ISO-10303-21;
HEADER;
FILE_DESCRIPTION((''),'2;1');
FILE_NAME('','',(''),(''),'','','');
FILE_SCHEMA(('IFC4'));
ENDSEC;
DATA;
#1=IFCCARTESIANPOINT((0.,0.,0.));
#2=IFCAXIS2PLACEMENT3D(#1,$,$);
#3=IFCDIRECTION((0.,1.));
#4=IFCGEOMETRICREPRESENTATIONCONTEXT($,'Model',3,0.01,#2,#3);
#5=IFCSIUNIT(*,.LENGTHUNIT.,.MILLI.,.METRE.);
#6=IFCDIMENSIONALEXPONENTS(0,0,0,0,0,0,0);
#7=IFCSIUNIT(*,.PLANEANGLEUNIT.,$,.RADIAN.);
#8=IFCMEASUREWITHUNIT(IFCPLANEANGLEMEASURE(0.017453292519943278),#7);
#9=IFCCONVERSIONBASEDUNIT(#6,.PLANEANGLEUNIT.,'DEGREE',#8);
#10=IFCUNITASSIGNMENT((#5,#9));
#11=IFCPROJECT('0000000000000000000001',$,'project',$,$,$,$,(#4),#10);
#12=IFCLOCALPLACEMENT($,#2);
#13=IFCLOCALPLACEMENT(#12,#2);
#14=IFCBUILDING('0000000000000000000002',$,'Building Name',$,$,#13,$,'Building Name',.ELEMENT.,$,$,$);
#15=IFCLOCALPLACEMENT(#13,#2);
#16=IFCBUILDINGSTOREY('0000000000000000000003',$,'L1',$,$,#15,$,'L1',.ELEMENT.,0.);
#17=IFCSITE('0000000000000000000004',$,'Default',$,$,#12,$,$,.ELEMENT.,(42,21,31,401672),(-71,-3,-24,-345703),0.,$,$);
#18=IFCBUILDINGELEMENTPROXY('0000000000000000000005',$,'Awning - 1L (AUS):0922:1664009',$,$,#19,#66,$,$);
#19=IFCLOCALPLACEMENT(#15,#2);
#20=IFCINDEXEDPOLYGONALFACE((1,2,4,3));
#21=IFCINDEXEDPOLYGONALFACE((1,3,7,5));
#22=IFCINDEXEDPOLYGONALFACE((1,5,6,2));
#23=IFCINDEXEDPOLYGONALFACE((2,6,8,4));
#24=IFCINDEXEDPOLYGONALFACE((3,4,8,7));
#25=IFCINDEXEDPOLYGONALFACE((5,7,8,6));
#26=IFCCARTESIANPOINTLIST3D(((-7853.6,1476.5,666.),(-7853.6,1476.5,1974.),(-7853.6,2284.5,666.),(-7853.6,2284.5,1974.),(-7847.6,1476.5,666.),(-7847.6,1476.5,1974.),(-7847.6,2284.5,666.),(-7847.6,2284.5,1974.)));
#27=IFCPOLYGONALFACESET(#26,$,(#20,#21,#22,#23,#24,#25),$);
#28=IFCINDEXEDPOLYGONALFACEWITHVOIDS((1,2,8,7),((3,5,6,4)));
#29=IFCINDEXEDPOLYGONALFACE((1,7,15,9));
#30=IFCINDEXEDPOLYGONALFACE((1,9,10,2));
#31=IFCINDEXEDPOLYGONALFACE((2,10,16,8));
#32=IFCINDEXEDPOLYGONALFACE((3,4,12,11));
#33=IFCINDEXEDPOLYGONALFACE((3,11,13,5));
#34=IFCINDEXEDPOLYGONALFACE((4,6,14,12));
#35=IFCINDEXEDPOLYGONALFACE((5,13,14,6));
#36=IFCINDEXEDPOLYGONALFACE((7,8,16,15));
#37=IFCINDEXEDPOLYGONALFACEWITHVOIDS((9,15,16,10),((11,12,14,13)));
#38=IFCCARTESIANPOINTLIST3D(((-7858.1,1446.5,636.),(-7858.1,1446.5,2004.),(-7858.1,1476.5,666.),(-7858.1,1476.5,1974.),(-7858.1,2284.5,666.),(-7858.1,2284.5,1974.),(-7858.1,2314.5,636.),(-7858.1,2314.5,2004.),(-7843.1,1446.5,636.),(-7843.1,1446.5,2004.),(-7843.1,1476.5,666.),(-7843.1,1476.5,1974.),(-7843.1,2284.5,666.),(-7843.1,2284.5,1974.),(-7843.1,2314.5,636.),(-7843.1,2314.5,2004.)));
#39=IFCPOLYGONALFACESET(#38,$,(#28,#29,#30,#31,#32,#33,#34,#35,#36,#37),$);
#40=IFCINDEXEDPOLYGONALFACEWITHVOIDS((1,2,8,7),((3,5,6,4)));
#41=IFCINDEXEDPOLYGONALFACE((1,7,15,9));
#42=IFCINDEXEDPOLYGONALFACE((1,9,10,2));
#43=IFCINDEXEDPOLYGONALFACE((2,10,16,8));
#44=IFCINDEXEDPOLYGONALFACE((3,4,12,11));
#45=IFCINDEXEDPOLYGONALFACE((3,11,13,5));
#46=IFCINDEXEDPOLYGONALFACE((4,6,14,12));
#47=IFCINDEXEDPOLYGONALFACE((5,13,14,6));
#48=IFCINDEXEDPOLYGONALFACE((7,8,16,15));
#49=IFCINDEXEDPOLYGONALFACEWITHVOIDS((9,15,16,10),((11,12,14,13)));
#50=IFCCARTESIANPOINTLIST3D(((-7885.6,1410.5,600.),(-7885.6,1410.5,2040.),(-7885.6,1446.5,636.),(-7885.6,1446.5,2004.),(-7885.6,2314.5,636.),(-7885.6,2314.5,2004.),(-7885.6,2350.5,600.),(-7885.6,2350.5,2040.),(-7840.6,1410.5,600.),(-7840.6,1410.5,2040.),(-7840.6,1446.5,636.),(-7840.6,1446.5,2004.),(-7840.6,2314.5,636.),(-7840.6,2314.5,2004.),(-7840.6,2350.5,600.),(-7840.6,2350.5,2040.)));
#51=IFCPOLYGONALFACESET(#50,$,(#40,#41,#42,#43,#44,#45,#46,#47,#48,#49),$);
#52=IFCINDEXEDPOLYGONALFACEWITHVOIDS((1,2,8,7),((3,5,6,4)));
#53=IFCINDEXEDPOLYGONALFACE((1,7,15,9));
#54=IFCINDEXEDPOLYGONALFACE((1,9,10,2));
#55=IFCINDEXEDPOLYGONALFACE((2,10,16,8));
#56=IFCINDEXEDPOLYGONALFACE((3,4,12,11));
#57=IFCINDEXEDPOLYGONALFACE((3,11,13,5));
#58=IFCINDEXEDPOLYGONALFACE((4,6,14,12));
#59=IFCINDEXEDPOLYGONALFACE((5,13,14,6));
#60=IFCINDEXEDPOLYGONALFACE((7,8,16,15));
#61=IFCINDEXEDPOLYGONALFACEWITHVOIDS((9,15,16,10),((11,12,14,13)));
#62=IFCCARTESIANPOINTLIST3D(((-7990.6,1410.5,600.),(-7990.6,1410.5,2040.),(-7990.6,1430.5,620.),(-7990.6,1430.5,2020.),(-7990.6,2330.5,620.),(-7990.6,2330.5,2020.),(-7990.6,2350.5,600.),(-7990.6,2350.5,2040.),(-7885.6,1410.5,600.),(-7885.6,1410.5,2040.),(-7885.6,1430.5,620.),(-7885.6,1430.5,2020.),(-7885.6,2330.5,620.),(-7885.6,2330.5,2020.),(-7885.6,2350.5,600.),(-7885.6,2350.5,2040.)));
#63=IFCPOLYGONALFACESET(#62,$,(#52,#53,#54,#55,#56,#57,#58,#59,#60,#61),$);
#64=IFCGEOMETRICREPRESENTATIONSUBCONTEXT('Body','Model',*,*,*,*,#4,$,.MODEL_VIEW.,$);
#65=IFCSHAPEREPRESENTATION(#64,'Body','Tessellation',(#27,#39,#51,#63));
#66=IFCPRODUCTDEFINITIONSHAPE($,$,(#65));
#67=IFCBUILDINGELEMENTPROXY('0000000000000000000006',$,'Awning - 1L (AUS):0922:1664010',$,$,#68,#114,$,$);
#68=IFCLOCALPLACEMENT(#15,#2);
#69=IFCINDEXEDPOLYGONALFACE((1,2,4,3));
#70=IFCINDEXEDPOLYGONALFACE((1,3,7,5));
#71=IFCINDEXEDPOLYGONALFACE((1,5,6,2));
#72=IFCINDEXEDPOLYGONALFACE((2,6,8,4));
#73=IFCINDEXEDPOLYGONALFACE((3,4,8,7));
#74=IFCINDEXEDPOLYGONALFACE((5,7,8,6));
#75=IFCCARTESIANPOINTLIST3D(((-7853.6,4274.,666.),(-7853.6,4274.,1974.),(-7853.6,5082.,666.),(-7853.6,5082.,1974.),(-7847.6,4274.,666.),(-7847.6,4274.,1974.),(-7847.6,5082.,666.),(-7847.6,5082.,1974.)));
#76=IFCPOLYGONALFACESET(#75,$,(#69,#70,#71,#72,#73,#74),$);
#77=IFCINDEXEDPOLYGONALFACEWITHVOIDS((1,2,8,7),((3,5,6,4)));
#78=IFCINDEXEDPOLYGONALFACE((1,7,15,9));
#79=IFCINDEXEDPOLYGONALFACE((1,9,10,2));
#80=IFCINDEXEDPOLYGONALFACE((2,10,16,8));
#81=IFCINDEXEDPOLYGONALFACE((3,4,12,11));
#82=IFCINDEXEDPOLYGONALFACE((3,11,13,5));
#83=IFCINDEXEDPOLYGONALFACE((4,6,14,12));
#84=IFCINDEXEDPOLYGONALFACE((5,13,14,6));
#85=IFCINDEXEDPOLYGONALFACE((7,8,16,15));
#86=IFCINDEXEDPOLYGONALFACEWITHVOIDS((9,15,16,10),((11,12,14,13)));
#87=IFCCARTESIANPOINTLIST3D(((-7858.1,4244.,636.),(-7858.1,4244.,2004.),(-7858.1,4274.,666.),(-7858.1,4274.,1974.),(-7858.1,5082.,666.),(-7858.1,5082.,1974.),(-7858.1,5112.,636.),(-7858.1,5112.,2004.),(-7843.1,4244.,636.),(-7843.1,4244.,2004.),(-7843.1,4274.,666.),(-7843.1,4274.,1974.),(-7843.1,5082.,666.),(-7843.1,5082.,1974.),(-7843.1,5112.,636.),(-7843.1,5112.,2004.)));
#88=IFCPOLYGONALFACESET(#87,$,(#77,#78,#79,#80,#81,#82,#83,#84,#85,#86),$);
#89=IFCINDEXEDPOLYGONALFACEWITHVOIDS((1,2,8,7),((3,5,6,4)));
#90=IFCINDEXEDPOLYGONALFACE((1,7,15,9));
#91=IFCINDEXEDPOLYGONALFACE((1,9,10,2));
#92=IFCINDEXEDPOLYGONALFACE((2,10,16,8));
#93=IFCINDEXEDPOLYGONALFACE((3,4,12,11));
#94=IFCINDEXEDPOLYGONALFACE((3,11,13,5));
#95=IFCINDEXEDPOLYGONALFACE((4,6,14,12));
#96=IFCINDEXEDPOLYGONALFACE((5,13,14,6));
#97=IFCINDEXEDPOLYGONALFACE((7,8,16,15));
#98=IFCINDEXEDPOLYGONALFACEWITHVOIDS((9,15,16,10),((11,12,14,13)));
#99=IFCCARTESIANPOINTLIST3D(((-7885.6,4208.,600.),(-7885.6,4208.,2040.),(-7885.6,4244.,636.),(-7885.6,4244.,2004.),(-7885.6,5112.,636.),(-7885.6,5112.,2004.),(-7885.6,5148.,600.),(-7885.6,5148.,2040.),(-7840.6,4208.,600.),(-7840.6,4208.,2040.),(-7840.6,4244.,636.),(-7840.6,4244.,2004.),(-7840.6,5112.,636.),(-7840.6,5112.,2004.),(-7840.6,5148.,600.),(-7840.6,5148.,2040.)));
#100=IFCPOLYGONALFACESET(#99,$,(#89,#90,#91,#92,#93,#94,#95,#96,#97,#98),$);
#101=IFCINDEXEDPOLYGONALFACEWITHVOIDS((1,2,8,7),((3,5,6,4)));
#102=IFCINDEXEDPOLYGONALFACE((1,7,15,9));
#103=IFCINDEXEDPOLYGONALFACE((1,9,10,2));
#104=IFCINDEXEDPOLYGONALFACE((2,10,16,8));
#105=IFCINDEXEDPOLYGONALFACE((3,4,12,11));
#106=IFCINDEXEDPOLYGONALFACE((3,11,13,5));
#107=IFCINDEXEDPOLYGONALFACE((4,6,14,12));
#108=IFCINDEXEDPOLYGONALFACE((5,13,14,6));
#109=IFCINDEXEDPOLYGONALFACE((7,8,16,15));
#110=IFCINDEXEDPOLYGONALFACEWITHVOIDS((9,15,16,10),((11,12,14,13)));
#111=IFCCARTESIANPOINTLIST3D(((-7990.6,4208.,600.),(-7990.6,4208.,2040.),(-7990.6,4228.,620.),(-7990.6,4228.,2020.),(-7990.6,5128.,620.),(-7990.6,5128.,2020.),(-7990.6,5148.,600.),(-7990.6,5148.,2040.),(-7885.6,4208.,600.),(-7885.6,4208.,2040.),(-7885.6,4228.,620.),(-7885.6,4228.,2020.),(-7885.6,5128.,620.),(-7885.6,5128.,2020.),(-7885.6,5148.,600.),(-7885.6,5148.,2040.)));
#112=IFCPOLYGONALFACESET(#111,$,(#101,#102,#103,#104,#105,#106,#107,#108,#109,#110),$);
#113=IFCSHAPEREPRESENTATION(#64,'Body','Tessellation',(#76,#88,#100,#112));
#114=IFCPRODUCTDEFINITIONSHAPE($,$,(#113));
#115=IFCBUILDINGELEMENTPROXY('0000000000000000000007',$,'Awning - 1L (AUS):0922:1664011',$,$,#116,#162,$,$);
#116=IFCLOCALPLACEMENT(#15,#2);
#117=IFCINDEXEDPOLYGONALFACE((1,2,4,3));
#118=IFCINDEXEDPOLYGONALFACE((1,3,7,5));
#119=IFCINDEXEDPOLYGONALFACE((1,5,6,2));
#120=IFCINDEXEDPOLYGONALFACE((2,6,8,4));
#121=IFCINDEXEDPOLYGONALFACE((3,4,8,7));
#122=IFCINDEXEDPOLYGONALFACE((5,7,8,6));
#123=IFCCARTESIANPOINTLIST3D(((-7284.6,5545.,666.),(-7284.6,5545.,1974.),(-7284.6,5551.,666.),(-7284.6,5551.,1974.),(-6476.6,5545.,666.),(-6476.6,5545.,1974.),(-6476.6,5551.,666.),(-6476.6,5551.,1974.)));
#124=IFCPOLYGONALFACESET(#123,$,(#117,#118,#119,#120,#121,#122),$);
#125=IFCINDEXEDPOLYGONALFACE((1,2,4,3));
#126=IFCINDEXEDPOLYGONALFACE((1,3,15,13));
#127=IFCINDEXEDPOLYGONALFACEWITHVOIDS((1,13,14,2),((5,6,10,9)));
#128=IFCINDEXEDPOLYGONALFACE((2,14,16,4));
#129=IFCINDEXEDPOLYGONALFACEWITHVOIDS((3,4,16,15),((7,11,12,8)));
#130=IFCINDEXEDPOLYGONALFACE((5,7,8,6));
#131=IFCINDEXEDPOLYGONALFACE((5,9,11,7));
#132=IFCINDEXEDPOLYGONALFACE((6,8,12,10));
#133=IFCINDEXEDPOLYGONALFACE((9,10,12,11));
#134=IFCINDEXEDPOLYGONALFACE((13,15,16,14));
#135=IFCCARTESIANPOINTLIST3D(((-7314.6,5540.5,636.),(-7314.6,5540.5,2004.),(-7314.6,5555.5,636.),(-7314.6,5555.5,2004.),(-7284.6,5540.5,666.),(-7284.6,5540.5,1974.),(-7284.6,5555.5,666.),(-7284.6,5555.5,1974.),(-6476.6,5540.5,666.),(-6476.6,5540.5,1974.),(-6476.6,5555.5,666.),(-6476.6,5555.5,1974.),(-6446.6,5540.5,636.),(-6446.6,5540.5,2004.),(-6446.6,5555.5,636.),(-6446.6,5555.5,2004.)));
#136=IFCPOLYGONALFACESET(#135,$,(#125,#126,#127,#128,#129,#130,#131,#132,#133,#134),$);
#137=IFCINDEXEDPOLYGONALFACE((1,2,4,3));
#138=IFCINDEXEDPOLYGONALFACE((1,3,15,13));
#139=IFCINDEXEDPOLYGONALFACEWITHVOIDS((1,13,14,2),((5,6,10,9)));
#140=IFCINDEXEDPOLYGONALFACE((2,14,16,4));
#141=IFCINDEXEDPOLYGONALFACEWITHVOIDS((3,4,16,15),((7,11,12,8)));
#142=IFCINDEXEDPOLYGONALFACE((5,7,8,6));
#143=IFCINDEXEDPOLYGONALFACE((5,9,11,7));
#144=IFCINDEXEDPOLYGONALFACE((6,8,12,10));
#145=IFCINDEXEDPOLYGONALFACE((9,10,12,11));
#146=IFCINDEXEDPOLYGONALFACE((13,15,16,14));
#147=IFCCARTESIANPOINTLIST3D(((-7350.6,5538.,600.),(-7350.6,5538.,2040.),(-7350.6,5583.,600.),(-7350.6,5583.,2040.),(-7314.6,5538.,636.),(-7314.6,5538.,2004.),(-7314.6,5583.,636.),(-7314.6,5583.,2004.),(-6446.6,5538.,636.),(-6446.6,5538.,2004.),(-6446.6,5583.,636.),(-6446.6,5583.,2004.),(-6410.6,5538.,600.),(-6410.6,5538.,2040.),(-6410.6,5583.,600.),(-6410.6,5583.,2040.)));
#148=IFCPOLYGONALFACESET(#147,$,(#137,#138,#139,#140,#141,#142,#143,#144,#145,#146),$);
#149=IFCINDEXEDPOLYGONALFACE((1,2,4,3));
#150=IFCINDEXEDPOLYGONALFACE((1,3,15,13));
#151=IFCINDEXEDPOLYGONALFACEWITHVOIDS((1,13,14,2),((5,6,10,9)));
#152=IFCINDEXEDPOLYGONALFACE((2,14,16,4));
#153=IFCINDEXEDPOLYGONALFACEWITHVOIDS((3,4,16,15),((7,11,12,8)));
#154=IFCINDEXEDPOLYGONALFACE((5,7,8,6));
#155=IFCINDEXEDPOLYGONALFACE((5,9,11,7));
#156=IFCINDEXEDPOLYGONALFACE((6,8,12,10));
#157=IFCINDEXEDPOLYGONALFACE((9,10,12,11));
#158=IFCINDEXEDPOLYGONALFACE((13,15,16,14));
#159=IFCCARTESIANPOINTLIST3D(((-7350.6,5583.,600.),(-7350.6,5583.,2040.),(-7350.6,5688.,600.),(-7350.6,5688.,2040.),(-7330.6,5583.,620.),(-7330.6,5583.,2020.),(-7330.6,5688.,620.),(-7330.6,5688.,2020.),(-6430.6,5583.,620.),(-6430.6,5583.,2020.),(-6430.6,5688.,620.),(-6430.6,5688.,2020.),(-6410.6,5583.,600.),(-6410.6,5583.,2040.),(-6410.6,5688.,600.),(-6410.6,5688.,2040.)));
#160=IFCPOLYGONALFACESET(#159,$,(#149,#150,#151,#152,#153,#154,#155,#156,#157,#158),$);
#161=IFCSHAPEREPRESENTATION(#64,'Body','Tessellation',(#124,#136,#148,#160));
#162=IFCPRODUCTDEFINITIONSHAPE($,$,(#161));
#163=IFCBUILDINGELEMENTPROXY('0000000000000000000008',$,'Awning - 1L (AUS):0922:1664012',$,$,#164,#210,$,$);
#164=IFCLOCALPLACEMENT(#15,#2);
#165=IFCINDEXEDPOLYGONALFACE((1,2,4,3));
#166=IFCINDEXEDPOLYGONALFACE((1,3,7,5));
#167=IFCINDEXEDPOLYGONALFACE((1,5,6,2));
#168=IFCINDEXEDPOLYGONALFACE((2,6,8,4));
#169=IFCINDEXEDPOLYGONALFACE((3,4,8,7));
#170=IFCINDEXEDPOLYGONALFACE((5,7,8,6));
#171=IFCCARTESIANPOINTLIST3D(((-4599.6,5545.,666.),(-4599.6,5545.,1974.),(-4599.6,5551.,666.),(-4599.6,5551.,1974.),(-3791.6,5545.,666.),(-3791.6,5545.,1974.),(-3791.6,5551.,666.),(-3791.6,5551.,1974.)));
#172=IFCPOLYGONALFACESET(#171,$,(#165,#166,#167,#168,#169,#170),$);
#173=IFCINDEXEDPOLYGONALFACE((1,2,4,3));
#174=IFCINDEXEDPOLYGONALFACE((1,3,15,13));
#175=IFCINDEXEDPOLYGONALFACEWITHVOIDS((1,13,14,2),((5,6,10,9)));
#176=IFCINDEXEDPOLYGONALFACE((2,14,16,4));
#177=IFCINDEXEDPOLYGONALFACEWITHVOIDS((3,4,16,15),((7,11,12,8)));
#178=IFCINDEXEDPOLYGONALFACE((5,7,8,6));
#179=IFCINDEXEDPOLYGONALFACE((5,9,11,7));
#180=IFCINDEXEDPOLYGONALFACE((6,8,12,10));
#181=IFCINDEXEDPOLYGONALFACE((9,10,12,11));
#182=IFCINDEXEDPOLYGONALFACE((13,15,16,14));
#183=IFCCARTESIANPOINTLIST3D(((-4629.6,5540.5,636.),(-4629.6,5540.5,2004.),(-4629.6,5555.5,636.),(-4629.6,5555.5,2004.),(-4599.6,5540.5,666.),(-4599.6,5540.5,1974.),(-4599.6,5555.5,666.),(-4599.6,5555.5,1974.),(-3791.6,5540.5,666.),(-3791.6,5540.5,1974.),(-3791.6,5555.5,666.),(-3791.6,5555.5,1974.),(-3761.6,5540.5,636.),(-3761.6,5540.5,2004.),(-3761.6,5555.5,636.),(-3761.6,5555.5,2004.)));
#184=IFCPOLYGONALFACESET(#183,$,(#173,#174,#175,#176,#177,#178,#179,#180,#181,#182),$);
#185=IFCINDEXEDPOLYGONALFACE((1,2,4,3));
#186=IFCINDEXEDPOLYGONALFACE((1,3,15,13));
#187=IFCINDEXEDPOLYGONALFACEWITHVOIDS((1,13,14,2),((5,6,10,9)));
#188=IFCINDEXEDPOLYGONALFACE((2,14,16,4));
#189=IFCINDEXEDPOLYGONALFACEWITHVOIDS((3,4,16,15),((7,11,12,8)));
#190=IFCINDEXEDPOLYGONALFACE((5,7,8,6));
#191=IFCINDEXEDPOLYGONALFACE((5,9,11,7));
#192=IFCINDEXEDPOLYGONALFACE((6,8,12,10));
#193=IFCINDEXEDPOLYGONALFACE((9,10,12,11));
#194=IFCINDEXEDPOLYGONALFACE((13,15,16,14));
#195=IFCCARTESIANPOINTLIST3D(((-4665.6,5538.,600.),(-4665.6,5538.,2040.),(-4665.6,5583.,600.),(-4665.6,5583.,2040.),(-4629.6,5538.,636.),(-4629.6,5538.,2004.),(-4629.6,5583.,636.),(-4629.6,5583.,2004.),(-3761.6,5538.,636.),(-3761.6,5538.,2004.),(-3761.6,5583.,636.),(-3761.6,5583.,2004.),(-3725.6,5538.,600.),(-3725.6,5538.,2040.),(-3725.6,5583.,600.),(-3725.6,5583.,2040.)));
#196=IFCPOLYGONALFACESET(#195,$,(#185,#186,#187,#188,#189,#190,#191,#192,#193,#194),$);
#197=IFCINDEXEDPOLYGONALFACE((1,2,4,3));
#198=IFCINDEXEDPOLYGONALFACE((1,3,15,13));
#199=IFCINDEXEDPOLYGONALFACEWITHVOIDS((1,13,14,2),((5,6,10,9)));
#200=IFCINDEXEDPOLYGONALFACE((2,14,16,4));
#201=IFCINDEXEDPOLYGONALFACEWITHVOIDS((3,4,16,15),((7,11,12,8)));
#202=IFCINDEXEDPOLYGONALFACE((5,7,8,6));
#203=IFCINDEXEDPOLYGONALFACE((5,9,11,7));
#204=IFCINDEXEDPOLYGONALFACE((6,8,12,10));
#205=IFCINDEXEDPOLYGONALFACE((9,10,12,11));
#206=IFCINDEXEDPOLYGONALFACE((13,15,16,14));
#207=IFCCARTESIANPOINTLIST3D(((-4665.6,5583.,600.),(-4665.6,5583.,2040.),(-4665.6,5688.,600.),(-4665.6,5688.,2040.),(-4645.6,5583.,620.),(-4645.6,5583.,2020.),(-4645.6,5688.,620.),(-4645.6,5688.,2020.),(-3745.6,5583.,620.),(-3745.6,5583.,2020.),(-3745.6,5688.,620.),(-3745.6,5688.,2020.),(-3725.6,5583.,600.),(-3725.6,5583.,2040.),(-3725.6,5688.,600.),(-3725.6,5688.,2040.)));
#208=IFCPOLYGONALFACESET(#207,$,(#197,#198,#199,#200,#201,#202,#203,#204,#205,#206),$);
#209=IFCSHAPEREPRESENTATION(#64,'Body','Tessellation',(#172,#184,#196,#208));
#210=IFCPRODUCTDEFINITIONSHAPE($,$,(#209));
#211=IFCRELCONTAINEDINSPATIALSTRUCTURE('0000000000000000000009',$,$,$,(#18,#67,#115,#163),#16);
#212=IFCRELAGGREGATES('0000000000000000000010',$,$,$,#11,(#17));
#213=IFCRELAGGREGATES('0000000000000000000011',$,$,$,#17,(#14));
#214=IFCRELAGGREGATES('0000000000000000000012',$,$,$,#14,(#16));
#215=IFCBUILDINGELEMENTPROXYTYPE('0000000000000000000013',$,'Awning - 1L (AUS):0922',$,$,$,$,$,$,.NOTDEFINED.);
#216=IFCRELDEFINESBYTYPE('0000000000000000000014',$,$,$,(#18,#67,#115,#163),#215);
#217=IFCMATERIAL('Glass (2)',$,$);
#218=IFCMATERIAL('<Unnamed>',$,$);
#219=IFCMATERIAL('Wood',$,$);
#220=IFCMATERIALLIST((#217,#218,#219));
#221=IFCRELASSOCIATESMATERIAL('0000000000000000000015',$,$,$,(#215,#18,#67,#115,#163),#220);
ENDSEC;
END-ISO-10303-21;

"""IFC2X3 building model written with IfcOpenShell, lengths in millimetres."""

from ifc_helpers import new_model, entity, si_unit, converted_unit, direction, frame, frame_2d, origin, place, context, subcontext, project, spatial, polyline, rectangle, outline, extrude, source, transform, mapped, material, material_list, type_object, type_shapes, element, save


model = new_model("IFC2X3")

# Units and contexts
model_context = context("Model", 3, precision=0.01, world=origin(), true_north=direction((0.0, 1.0)))
body_context = subcontext(model_context, "Body", "Model", "MODEL_VIEW")
ifc_project = project(units=[si_unit("LENGTHUNIT", "METRE", prefix="MILLI"), converted_unit("PLANEANGLEUNIT", "DEGREE", entity("IfcPlaneAngleMeasure", 0.017453292519943278), si_unit("PLANEANGLEUNIT", "RADIAN"), dimensions=[0, 0, 0, 0, 0, 0, 0])], contexts=[model_context])

# Site, building, storey
site_placement = place(None, origin())
site = spatial("IfcSite", under=ifc_project, at=site_placement, Name="Default", CompositionType="ELEMENT", RefLatitude=(42, 21, 31, 401672), RefLongitude=(-71, -3, -24, -345703), RefElevation=0.0)
building_placement = place(site_placement, origin())
building = spatial("IfcBuilding", under=site, at=building_placement, Name="Building Name", LongName="Building Name", CompositionType="ELEMENT")
storey_placement = place(building_placement, origin())
storey = spatial("IfcBuildingStorey", under=building, at=storey_placement, Name="L1", LongName="L1", CompositionType="ELEMENT", Elevation=0.0)

# Building element proxies
ifc_material_1 = material(Name="Glass (2)")
ifc_material_2 = material(Name="<Unnamed>")
ifc_material_3 = material(Name="Wood")
ifc_material_list_1 = material_list([ifc_material_1, ifc_material_2, ifc_material_3])
building_element_proxy_type_1 = type_object("IfcBuildingElementProxyType", Name="Awning - 1L (AUS):0922", PredefinedType="NOTDEFINED", material=ifc_material_list_1)
shared_shape_1 = source(origin(), body_context, "Body", "SweptSolid", [
    extrude(rectangle(XDim=6.0, YDim=808.0, at=frame_2d((0.0, 0.0), x_axis=(1.0, 0.0))), frame((326.2, 12.5, 966.0), z_axis=(0.0, 0.0, 1.0), x_axis=(0.0, 1.0, 0.0)), (0.0, 0.0, 1.0), 1308.0),
    extrude(outline(polyline([(-684.0, -434.0), (684.0, -434.0), (684.0, 434.0), (-684.0, 434.0), (-684.0, -434.0)]), holes=[polyline([(654.0, -404.0), (-654.0, -404.0), (-654.0, 404.0), (654.0, 404.0), (654.0, -404.0)])]), frame((326.2, 5.0, 1620.0), z_axis=(0.0, 1.0, 0.0), x_axis=(0.0, 0.0, 1.0)), (0.0, 0.0, 1.0), 15.0),
    extrude(outline(polyline([(-720.0, -470.0), (720.0, -470.0), (720.0, 470.0), (-720.0, 470.0), (-720.0, -470.0)]), holes=[polyline([(684.0, -434.0), (-684.0, -434.0), (-684.0, 434.0), (684.0, 434.0), (684.0, -434.0)])]), frame((326.2, -22.5, 1620.0), z_axis=(0.0, 1.0, 0.0), x_axis=(0.0, 0.0, 1.0)), (0.0, 0.0, 1.0), 45.0),
    extrude(outline(polyline([(-720.0, -470.0), (720.0, -470.0), (720.0, 470.0), (-720.0, 470.0), (-720.0, -470.0)]), holes=[polyline([(700.0, -450.0), (-700.0, -450.0), (-700.0, 450.0), (700.0, 450.0), (700.0, -450.0)])]), frame((326.2, -127.5, 1620.0), z_axis=(0.0, 1.0, 0.0), x_axis=(0.0, 0.0, 1.0)), (0.0, 0.0, 1.0), 105.0),
])
type_shapes(building_element_proxy_type_1, [shared_shape_1])
for number, where, z_axis, x_axis, name in (
    (1, (-7863.1, 2206.7, -300.0), (0.0, 0.0, 1.0), (0.0, -1.0, 0.0), "Awning - 1L (AUS):0922:1664009"),
    (2, (-7863.1, 5004.2, -300.0), (0.0, 0.0, 1.0), (0.0, -1.0, 0.0), "Awning - 1L (AUS):0922:1664010"),
    (3, (-6554.4, 5560.5, -300.0), (0.0, 0.0, 1.0), (-1.0, 0.0, 0.0), "Awning - 1L (AUS):0922:1664011"),
    (4, (-3869.4, 5560.5, -300.0), (0.0, 0.0, 1.0), (-1.0, 0.0, 0.0), "Awning - 1L (AUS):0922:1664012"),
):
    element("IfcBuildingElementProxy", number, at=place(storey_placement, frame(where, z_axis=z_axis, x_axis=x_axis)), inside=storey, type_object=building_element_proxy_type_1, material=ifc_material_list_1, Name=name, context=body_context, shape_type="MappedRepresentation", body=[
        mapped(shared_shape_1, transform((0.0, 0.0, 0.0), scale=1.0)),
    ])

save(model, "model.ifc")
